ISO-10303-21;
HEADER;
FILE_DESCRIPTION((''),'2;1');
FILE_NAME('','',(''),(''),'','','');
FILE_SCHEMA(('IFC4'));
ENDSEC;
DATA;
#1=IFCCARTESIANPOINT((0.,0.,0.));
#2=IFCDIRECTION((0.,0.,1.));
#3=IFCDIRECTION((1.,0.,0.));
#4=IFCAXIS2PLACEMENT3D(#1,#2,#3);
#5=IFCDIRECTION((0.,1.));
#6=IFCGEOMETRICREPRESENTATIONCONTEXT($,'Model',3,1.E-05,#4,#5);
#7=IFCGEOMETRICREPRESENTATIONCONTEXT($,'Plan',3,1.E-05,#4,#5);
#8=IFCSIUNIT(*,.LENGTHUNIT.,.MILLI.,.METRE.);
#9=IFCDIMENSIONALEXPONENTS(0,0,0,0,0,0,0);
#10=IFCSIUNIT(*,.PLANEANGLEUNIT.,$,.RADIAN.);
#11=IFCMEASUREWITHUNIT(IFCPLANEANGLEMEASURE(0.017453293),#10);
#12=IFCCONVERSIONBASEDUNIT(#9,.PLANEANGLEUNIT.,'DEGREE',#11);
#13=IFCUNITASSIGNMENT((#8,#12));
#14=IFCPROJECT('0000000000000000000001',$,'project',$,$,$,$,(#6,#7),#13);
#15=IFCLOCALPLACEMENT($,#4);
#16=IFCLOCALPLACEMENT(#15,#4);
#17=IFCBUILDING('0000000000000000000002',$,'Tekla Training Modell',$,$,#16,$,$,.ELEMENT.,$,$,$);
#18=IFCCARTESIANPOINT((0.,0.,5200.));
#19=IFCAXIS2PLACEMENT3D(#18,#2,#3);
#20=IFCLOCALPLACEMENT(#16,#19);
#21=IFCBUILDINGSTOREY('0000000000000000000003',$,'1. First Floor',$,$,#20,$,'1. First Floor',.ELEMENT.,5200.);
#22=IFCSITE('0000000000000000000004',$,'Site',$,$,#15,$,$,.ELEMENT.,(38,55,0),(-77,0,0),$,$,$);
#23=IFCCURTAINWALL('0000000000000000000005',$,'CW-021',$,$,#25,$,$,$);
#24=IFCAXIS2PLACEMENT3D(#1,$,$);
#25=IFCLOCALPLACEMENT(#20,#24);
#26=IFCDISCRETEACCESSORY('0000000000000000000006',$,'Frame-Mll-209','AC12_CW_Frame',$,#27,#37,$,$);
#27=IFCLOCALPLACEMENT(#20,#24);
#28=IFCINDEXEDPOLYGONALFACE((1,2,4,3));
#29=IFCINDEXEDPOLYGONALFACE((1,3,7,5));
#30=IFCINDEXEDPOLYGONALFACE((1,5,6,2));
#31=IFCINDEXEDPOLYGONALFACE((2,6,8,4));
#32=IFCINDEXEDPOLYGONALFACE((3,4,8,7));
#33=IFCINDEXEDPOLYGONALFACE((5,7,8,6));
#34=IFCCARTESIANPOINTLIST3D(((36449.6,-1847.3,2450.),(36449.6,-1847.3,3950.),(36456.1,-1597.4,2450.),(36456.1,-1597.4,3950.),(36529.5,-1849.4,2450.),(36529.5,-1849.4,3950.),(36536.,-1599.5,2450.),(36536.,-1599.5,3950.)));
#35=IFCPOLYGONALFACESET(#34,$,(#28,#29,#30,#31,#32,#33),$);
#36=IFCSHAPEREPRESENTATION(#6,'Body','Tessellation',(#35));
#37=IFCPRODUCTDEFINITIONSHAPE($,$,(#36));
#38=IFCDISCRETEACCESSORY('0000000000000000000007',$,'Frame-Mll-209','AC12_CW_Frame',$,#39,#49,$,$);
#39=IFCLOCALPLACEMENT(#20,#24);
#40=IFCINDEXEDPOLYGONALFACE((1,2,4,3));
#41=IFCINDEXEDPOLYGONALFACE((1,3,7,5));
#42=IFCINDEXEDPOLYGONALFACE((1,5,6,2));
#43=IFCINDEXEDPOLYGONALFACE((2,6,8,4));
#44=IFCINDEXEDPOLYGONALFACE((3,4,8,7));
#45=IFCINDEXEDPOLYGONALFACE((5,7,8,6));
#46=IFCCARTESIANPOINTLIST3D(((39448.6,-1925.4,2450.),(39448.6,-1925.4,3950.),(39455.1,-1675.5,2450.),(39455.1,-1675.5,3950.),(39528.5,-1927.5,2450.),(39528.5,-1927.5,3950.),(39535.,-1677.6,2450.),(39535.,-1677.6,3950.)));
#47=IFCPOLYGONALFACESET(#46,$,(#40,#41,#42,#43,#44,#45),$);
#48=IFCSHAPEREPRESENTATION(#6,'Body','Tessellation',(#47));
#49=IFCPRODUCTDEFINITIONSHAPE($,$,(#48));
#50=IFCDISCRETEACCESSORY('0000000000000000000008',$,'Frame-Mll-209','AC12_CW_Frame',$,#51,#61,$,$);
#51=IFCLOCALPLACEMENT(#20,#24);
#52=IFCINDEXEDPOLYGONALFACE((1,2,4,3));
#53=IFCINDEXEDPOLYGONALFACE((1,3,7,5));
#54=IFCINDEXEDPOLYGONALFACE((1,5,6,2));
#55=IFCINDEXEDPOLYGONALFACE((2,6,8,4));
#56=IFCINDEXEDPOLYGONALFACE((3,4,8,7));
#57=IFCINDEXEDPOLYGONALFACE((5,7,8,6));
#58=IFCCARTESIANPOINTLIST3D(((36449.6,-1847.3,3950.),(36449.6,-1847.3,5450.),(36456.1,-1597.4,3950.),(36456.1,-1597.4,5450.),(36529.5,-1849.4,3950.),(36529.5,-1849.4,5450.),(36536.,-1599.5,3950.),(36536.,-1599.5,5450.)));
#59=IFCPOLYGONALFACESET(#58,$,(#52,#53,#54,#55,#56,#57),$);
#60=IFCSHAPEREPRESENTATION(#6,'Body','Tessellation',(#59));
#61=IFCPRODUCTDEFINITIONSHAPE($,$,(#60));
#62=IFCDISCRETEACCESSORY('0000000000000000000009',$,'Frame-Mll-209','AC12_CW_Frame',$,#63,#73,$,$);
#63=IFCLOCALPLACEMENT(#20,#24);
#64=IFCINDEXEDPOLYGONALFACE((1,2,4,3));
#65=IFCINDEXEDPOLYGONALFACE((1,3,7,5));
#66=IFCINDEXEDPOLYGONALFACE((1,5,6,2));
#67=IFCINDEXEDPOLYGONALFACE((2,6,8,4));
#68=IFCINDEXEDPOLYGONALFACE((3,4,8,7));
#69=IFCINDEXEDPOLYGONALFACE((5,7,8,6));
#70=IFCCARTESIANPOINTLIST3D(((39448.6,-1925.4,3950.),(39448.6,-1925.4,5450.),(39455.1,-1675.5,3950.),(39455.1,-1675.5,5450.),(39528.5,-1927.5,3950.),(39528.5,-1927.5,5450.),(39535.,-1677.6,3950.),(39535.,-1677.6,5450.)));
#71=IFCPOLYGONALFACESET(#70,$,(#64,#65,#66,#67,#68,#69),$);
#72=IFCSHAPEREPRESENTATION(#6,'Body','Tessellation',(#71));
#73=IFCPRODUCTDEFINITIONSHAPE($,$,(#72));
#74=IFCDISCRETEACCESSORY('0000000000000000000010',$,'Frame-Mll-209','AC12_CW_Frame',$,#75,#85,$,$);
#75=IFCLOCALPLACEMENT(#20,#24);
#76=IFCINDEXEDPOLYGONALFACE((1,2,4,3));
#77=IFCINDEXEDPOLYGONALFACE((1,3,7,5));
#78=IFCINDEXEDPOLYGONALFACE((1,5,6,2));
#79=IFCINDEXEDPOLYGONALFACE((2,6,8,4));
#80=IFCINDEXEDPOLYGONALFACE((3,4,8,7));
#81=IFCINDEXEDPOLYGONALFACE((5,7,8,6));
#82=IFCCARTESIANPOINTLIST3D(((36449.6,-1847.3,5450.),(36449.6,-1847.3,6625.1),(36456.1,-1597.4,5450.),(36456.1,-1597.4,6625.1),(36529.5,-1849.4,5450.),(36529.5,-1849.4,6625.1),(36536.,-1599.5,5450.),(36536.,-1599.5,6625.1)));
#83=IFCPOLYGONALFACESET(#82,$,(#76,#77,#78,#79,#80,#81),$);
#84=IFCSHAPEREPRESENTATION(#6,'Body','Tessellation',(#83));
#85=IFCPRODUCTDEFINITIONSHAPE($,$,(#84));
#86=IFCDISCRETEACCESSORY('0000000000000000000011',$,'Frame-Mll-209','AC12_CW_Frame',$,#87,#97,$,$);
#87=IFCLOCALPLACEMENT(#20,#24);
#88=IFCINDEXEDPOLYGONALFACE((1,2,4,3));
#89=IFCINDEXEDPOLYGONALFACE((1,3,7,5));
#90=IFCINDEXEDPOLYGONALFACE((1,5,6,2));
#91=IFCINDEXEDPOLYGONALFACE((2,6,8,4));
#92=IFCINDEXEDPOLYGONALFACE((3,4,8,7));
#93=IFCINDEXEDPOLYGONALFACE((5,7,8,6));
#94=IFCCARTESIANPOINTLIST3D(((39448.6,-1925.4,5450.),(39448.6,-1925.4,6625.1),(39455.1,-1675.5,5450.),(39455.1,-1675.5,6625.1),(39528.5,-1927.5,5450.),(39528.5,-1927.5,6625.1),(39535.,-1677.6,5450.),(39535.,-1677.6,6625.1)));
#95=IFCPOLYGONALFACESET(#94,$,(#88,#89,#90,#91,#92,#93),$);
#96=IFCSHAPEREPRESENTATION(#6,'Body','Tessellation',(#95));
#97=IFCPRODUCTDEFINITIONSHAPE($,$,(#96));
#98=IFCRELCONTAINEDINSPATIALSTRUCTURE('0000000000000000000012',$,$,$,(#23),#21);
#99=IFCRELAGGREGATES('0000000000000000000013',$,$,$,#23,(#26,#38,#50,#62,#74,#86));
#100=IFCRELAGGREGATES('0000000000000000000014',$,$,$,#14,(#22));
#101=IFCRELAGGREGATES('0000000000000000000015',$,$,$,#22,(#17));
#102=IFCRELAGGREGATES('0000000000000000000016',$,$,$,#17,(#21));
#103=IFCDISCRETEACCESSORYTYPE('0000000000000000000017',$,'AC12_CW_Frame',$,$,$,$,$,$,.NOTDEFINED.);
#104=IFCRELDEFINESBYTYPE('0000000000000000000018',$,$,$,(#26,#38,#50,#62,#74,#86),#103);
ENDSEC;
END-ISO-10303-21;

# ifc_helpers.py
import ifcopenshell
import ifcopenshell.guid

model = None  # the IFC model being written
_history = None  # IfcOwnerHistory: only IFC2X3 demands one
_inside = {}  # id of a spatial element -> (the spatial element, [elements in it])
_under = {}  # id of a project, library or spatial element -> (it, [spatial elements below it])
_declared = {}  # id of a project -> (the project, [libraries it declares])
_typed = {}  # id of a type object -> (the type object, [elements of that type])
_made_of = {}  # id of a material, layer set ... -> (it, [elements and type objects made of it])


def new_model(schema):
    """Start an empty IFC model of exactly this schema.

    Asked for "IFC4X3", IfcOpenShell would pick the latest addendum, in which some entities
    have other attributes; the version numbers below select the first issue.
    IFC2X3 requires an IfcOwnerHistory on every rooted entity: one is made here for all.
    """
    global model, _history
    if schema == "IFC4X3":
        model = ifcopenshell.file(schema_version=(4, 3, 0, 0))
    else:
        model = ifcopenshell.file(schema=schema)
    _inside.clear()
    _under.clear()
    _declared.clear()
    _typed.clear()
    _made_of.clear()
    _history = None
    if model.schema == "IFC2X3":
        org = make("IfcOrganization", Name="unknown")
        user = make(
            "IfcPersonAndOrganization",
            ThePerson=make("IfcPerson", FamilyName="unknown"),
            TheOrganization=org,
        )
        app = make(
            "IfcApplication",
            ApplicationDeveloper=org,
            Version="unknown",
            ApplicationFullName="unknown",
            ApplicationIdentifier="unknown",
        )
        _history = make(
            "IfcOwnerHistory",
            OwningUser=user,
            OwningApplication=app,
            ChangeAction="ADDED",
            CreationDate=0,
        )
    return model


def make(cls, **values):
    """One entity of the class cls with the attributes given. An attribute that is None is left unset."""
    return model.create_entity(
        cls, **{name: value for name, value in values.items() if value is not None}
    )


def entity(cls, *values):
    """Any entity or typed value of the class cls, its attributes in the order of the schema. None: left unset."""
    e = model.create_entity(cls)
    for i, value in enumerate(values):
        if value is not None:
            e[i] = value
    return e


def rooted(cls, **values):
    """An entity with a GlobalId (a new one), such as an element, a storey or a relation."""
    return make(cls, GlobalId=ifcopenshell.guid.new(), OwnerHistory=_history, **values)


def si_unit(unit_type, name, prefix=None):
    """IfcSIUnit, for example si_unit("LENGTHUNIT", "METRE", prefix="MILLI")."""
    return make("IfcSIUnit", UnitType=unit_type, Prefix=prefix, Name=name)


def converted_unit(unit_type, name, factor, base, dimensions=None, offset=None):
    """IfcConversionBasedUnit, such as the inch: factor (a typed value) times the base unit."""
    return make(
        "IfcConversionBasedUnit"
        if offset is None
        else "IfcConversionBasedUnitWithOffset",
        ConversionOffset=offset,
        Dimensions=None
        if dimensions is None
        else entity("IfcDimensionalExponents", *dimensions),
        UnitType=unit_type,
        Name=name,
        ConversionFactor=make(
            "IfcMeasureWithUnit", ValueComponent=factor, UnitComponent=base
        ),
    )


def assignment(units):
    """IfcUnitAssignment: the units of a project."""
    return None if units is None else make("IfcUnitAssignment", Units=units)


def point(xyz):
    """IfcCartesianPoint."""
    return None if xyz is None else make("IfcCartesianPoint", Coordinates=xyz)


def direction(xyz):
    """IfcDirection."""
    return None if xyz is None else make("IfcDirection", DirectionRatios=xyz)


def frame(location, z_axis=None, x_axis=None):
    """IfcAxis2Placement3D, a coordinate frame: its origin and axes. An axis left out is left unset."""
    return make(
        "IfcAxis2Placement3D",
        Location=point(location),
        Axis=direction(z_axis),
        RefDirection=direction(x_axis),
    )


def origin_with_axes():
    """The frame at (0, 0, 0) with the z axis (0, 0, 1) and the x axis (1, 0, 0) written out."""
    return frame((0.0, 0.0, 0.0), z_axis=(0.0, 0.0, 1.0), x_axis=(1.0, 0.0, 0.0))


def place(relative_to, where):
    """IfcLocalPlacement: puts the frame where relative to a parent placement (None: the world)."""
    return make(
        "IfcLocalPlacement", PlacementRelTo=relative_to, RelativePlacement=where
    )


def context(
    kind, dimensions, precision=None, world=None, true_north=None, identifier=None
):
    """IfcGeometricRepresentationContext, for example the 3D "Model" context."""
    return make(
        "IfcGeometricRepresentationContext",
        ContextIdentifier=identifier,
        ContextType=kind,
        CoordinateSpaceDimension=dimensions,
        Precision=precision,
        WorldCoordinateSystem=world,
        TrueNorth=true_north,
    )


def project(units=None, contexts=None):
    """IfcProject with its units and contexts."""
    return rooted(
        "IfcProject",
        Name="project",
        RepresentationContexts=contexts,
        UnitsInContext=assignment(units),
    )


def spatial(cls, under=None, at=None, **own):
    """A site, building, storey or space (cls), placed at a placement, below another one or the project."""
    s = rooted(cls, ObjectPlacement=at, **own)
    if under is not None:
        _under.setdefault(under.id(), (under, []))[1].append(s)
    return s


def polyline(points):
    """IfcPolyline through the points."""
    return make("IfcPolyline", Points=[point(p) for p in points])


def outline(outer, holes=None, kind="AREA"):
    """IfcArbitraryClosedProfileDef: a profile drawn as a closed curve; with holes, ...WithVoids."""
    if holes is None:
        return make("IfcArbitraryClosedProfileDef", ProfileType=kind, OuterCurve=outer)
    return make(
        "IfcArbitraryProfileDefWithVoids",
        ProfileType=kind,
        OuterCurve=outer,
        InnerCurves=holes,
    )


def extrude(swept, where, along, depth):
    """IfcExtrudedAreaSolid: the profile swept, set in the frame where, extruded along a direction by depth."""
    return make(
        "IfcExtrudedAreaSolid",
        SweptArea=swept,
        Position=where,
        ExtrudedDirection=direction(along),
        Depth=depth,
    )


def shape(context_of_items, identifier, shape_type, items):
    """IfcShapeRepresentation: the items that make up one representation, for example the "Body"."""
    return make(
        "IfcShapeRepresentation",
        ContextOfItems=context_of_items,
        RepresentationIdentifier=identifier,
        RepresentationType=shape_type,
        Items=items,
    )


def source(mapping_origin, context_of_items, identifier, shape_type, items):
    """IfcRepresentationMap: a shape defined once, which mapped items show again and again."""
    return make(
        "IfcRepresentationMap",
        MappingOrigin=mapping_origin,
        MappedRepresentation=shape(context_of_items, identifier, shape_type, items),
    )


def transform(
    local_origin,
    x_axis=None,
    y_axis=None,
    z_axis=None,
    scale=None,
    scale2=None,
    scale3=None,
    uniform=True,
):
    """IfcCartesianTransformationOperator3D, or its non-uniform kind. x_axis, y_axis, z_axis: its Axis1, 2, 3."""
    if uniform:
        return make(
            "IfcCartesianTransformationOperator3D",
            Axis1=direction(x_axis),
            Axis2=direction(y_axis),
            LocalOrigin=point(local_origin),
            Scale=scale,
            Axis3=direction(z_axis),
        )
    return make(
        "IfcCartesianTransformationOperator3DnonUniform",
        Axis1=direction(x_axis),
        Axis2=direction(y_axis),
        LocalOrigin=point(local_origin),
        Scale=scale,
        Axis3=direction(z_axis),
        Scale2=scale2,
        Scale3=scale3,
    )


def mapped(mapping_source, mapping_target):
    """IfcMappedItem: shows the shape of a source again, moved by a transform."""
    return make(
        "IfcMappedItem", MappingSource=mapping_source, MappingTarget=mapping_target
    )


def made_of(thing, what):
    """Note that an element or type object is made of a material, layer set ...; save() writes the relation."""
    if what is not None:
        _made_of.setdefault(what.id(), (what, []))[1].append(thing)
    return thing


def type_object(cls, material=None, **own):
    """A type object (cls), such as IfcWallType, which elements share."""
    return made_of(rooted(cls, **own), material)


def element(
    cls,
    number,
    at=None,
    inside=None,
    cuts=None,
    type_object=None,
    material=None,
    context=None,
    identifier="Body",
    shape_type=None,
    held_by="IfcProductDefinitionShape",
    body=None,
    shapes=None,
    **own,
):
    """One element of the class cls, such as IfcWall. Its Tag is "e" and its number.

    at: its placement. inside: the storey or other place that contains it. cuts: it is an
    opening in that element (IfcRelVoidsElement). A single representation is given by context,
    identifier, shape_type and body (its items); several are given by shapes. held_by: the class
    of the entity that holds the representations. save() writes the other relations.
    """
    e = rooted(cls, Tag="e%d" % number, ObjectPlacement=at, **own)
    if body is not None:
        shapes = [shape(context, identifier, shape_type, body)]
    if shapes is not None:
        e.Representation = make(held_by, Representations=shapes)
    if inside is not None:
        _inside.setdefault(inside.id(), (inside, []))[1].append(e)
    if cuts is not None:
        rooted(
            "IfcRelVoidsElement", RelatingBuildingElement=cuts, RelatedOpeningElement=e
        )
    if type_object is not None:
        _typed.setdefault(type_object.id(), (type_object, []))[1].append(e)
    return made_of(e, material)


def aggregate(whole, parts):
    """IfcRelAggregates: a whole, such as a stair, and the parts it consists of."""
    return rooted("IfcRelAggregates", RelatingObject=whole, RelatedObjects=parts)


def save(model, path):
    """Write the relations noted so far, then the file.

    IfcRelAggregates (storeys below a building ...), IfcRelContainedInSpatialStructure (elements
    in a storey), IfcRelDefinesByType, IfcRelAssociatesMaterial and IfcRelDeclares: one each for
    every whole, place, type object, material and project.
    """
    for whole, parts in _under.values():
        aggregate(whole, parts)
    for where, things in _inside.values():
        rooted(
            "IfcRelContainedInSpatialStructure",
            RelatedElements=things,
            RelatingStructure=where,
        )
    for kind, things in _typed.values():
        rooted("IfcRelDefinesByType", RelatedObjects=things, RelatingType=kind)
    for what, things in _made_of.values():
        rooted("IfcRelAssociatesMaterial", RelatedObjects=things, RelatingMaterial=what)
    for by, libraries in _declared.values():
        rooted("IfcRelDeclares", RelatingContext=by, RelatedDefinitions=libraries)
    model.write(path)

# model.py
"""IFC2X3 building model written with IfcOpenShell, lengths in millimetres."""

from ifc_helpers import new_model, entity, si_unit, converted_unit, direction, frame, origin_with_axes, place, context, project, spatial, polyline, outline, extrude, source, transform, mapped, type_object, element, aggregate, save


model = new_model("IFC2X3")

# Units and contexts
model_context = context("Model", 3, precision=1e-05, world=origin_with_axes(), true_north=direction((0.0, 1.0)))
plan_context = context("Plan", 3, precision=1e-05, world=origin_with_axes(), true_north=direction((0.0, 1.0)))
ifc_project = project(units=[si_unit("LENGTHUNIT", "METRE", prefix="MILLI"), converted_unit("PLANEANGLEUNIT", "DEGREE", entity("IfcPlaneAngleMeasure", 0.017453293), si_unit("PLANEANGLEUNIT", "RADIAN"), dimensions=[0, 0, 0, 0, 0, 0, 0])], contexts=[model_context, plan_context])

# Site, building, storey
site_placement = place(None, origin_with_axes())
site = spatial("IfcSite", under=ifc_project, at=site_placement, Name="Site", CompositionType="ELEMENT", RefLatitude=(38, 55, 0), RefLongitude=(-77, 0, 0))
building_placement = place(site_placement, origin_with_axes())
building = spatial("IfcBuilding", under=site, at=building_placement, Name="Tekla Training Modell", CompositionType="ELEMENT")
storey_placement = place(building_placement, frame((0.0, 0.0, 5200.0), z_axis=(0.0, 0.0, 1.0), x_axis=(1.0, 0.0, 0.0)))
storey = spatial("IfcBuildingStorey", under=building, at=storey_placement, Name="1. First Floor", LongName="1. First Floor", CompositionType="ELEMENT", Elevation=5200.0)

# Curtain wall, discrete accessories
curtain_wall_placement = place(storey_placement, frame((9500.0, -1095.8, -550.0), z_axis=(0.0, 0.0, 1.0), x_axis=(0.999661, -0.026022, 0.0)))
curtain_wall = element("IfcCurtainWall", 1, at=curtain_wall_placement, inside=storey, Name="CW-021")
discrete_accessory_type = type_object("IfcDiscreteAccessoryType", Name="AC12_CW_Frame")
shared_shape_1 = source(origin_with_axes(), model_context, "Body", "SweptSolid", [
    extrude(outline(polyline([(0.0, 0.0), (250.0, 0.0), (250.0, -1500.0), (0.0, -1500.0), (0.0, 0.0)])), origin_with_axes(), (0.0, 0.0, 1.0), 80.0),
])
discrete_accessory_1_placement = place(storey_placement, frame((36456.1, -1597.4, 2450.0), z_axis=(0.999661, -0.026022, 0.0), x_axis=(-0.026022, -0.999661, 0.0)))
discrete_accessory_1 = element("IfcDiscreteAccessory", 2, at=discrete_accessory_1_placement, type_object=discrete_accessory_type, Name="Frame-Mll-209", Description="AC12_CW_Frame", context=model_context, shape_type="MappedRepresentation", body=[
    mapped(shared_shape_1, transform((0.0, 0.0, 0.0), scale=1.0)),
])
discrete_accessory_2_placement = place(storey_placement, frame((39455.1, -1675.5, 2450.0), z_axis=(0.999661, -0.026022, 0.0), x_axis=(-0.026022, -0.999661, 0.0)))
discrete_accessory_2 = element("IfcDiscreteAccessory", 3, at=discrete_accessory_2_placement, type_object=discrete_accessory_type, Name="Frame-Mll-209", Description="AC12_CW_Frame", context=model_context, shape_type="MappedRepresentation", body=[
    mapped(shared_shape_1, transform((0.0, 0.0, 0.0), scale=1.0)),
])
discrete_accessory_3_placement = place(storey_placement, frame((36456.1, -1597.4, 3950.0), z_axis=(0.999661, -0.026022, 0.0), x_axis=(-0.026022, -0.999661, 0.0)))
discrete_accessory_3 = element("IfcDiscreteAccessory", 4, at=discrete_accessory_3_placement, type_object=discrete_accessory_type, Name="Frame-Mll-209", Description="AC12_CW_Frame", context=model_context, shape_type="MappedRepresentation", body=[
    mapped(shared_shape_1, transform((0.0, 0.0, 0.0), scale=1.0)),
])
discrete_accessory_4_placement = place(storey_placement, frame((39455.1, -1675.5, 3950.0), z_axis=(0.999661, -0.026022, 0.0), x_axis=(-0.026022, -0.999661, 0.0)))
discrete_accessory_4 = element("IfcDiscreteAccessory", 5, at=discrete_accessory_4_placement, type_object=discrete_accessory_type, Name="Frame-Mll-209", Description="AC12_CW_Frame", context=model_context, shape_type="MappedRepresentation", body=[
    mapped(shared_shape_1, transform((0.0, 0.0, 0.0), scale=1.0)),
])
shared_shape_2 = source(origin_with_axes(), model_context, "Body", "SweptSolid", [
    extrude(outline(polyline([(0.0, 0.0), (250.0, 0.0), (250.0, -1175.1), (0.0, -1175.1), (0.0, 0.0)])), origin_with_axes(), (0.0, 0.0, 1.0), 80.0),
])
discrete_accessory_5_placement = place(storey_placement, frame((36456.1, -1597.4, 5450.0), z_axis=(0.999661, -0.026022, 0.0), x_axis=(-0.026022, -0.999661, 0.0)))
discrete_accessory_5 = element("IfcDiscreteAccessory", 6, at=discrete_accessory_5_placement, type_object=discrete_accessory_type, Name="Frame-Mll-209", Description="AC12_CW_Frame", context=model_context, shape_type="MappedRepresentation", body=[
    mapped(shared_shape_2, transform((0.0, 0.0, 0.0), scale=1.0)),
])
discrete_accessory_6_placement = place(storey_placement, frame((39455.1, -1675.5, 5450.0), z_axis=(0.999661, -0.026022, 0.0), x_axis=(-0.026022, -0.999661, 0.0)))
discrete_accessory_6 = element("IfcDiscreteAccessory", 7, at=discrete_accessory_6_placement, type_object=discrete_accessory_type, Name="Frame-Mll-209", Description="AC12_CW_Frame", context=model_context, shape_type="MappedRepresentation", body=[
    mapped(shared_shape_2, transform((0.0, 0.0, 0.0), scale=1.0)),
])
aggregate(curtain_wall, [discrete_accessory_1, discrete_accessory_2, discrete_accessory_3, discrete_accessory_4, discrete_accessory_5, discrete_accessory_6])

save(model, "model.ifc")
